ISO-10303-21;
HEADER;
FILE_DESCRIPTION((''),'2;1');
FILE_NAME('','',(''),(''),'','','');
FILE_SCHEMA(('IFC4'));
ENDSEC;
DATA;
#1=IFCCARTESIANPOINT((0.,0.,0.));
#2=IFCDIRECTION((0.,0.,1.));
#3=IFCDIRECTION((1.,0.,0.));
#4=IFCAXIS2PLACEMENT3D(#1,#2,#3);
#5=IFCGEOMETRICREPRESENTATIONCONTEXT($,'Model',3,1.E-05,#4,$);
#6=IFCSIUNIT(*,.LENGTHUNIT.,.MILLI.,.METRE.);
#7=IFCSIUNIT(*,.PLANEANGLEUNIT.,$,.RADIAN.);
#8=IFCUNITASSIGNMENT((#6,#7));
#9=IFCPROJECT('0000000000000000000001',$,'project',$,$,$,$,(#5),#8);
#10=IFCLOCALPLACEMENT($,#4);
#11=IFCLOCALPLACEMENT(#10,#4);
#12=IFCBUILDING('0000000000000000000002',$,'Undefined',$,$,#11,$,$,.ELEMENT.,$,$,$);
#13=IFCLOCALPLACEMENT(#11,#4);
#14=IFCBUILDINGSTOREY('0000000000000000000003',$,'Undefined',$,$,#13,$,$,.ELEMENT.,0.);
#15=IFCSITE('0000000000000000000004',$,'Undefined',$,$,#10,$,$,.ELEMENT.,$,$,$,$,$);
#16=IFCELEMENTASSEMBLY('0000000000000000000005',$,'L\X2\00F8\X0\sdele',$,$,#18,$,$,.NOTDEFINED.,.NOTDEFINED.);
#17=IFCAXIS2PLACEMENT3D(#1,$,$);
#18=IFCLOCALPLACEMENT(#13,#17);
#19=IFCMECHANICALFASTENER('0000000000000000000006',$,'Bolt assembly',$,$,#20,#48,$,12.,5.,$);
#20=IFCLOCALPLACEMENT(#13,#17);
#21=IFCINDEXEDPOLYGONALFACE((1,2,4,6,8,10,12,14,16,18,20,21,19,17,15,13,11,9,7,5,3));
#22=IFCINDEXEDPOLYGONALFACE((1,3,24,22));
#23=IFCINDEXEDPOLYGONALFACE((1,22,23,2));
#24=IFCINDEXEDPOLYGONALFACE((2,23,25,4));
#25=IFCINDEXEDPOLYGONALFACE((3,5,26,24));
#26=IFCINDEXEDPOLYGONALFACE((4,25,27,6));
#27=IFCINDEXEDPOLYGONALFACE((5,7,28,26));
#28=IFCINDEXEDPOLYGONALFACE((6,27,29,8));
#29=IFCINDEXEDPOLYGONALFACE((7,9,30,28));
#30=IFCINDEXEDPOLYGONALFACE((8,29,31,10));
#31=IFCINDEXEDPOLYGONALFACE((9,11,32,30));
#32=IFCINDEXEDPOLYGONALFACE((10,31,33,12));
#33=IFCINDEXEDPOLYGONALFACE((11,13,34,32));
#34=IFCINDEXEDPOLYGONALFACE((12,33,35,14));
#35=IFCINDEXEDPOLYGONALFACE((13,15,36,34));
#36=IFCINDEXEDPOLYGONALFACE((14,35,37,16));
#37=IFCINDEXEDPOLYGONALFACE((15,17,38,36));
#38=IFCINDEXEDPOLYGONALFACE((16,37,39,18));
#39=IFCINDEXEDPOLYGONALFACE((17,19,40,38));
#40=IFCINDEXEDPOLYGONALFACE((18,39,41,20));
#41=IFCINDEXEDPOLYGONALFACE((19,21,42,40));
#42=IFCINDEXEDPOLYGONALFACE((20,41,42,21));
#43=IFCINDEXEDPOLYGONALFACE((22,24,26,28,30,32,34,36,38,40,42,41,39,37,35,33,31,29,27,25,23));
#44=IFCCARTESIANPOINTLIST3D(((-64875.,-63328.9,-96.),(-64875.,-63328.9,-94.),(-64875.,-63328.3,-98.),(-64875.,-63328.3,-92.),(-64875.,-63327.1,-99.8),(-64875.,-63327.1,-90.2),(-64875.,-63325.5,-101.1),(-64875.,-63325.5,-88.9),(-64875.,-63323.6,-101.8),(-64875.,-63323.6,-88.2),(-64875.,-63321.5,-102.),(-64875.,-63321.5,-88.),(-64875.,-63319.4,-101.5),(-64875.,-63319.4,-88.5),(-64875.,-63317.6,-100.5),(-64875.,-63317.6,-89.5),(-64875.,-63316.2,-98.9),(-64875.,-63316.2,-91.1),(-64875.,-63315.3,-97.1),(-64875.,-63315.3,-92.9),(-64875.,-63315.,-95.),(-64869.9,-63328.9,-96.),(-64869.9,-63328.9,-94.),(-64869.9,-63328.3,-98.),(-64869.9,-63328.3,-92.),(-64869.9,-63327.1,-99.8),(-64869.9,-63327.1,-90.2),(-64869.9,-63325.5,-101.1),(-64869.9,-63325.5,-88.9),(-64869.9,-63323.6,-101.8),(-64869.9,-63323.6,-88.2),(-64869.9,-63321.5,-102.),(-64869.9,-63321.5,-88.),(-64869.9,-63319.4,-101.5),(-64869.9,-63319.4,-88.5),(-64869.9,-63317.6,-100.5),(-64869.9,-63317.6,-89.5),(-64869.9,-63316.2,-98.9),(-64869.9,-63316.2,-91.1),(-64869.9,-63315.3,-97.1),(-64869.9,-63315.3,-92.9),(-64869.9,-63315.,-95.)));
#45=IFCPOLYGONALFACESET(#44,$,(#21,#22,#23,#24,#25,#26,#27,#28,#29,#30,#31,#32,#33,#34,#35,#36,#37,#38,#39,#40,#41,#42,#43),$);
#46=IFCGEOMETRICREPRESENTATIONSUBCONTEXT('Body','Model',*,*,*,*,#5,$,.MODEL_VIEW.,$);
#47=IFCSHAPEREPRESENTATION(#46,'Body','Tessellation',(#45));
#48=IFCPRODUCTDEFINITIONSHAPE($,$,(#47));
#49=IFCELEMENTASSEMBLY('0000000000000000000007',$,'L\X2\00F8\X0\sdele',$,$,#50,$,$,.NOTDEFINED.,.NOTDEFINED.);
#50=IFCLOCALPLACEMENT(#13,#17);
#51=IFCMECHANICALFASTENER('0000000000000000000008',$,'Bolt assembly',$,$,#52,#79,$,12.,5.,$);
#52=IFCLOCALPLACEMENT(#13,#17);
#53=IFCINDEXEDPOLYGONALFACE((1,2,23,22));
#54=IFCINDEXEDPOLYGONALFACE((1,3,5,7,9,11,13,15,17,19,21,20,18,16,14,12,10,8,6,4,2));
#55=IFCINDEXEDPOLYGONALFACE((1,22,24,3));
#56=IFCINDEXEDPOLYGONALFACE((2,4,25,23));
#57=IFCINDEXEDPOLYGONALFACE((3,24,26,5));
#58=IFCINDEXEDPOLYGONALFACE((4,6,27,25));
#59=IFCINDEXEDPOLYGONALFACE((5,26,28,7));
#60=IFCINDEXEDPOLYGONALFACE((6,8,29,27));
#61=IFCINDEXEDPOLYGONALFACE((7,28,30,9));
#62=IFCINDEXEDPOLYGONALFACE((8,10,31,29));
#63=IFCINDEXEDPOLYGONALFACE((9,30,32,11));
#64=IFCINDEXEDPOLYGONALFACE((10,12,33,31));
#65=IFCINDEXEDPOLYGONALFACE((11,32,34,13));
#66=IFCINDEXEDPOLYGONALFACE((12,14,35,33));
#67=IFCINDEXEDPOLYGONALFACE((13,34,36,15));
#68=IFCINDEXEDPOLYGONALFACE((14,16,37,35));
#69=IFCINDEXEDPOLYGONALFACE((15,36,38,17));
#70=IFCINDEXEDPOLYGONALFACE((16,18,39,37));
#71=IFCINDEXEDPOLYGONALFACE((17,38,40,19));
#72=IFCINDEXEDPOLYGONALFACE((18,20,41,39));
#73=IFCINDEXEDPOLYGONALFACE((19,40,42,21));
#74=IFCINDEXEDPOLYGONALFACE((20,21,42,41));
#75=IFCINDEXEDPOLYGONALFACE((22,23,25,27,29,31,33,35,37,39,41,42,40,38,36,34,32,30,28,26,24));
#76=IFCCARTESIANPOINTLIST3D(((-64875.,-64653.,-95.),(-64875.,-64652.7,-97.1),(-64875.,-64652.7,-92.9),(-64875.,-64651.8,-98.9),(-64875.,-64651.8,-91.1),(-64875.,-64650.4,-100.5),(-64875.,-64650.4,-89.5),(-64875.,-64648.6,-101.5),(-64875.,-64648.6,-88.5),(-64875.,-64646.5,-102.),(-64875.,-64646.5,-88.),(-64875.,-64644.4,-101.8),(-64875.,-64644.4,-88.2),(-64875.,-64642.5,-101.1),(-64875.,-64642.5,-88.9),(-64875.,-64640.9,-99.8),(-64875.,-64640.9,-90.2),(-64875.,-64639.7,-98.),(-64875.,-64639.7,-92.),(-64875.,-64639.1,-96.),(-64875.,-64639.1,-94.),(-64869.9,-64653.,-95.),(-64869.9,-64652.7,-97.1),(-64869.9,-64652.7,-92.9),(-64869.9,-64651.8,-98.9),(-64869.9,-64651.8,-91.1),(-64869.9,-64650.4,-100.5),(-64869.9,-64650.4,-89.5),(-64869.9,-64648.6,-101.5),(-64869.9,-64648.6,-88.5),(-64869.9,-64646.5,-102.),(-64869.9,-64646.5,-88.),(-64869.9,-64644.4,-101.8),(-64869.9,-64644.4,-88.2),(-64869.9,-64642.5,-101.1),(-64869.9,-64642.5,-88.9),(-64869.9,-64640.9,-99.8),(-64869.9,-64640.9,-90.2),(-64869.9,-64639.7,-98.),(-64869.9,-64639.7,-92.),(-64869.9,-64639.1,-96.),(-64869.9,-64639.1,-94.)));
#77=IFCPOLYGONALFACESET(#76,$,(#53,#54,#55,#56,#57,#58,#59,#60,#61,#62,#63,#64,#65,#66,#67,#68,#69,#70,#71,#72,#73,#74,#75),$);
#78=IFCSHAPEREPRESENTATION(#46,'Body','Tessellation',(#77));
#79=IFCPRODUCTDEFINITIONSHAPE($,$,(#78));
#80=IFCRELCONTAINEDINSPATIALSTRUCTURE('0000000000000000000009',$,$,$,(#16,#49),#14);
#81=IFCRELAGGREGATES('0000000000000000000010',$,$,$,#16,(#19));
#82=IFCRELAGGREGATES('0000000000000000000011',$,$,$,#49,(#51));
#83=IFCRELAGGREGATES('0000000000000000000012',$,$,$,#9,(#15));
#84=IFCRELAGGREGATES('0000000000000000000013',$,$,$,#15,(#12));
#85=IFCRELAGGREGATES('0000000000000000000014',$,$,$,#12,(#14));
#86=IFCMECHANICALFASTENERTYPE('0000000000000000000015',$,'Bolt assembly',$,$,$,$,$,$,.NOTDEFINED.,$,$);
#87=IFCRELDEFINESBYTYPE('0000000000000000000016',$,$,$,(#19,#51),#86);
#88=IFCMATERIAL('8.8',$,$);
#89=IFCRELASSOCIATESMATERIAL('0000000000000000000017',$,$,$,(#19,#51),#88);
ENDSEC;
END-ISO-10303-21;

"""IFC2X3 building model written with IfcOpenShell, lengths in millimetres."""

from ifc_helpers import new_model, si_unit, frame, origin_with_axes, origin_2d_with_axis, place, context, subcontext, project, spatial, circle, extrude, source, transform, mapped, material, type_object, element, aggregate, save


model = new_model("IFC2X3")

# Units and contexts
model_context = context("Model", 3, precision=1e-05, world=origin_with_axes())
body_context = subcontext(model_context, "Body", "Model", "MODEL_VIEW")
ifc_project = project(units=[si_unit("LENGTHUNIT", "METRE", prefix="MILLI"), si_unit("PLANEANGLEUNIT", "RADIAN")], contexts=[model_context])

# Site, building, storey
site_placement = place(None, origin_with_axes())
site = spatial("IfcSite", under=ifc_project, at=site_placement, Name="Undefined", CompositionType="ELEMENT")
building_placement = place(site_placement, origin_with_axes())
building = spatial("IfcBuilding", under=site, at=building_placement, Name="Undefined", CompositionType="ELEMENT")
storey_placement = place(building_placement, origin_with_axes())
storey = spatial("IfcBuildingStorey", under=building, at=storey_placement, Name="Undefined", CompositionType="ELEMENT", Elevation=0.0)

# Element assembly
assembly_1_placement = place(storey_placement, origin_with_axes())
assembly_1 = element("IfcElementAssembly", 1, at=assembly_1_placement, inside=storey, Name="Løsdele", AssemblyPlace="NOTDEFINED", PredefinedType="NOTDEFINED")

# Mechanical fastener
ifc_material_1 = material(Name="8.8")
mechanical_fastener_type = type_object("IfcMechanicalFastenerType", Name="Bolt assembly")
shared_shape_1 = source(origin_with_axes(), body_context, "Body", "SweptSolid", [
    extrude(circle(Radius=7.0, at=origin_2d_with_axis()), frame((0.0, 5.0, 0.0), z_axis=(0.0, 1.0, 0.0), x_axis=(1.0, 0.0, 0.0)), (0.0, 0.0, 1.0), 5.1),
])
mechanical_fastener_1_placement = place(assembly_1_placement, frame((-64880.0, -63322.0, -95.0), z_axis=(0.0, 0.0, -1.0), x_axis=(0.0, 1.0, 0.0)))
mechanical_fastener_1 = element("IfcMechanicalFastener", 2, at=mechanical_fastener_1_placement, type_object=mechanical_fastener_type, material=ifc_material_1, Name="Bolt assembly", NominalDiameter=12.0, NominalLength=5.0, context=body_context, shape_type="MappedRepresentation", body=[
    mapped(shared_shape_1, transform((0.0, 0.0, 0.0))),
])
aggregate(assembly_1, [mechanical_fastener_1])

# Element assembly, mechanical fastener
assembly_2_placement = place(storey_placement, origin_with_axes())
assembly_2 = element("IfcElementAssembly", 3, at=assembly_2_placement, inside=storey, Name="Løsdele", AssemblyPlace="NOTDEFINED", PredefinedType="NOTDEFINED")
mechanical_fastener_2_placement = place(assembly_2_placement, frame((-64880.0, -64646.0, -95.0), z_axis=(0.0, 0.0, 1.0), x_axis=(0.0, -1.0, 0.0)))
mechanical_fastener_2 = element("IfcMechanicalFastener", 4, at=mechanical_fastener_2_placement, type_object=mechanical_fastener_type, material=ifc_material_1, Name="Bolt assembly", NominalDiameter=12.0, NominalLength=5.0, context=body_context, shape_type="MappedRepresentation", body=[
    mapped(shared_shape_1, transform((0.0, 0.0, 0.0))),
])
aggregate(assembly_2, [mechanical_fastener_2])

save(model, "model.ifc")
